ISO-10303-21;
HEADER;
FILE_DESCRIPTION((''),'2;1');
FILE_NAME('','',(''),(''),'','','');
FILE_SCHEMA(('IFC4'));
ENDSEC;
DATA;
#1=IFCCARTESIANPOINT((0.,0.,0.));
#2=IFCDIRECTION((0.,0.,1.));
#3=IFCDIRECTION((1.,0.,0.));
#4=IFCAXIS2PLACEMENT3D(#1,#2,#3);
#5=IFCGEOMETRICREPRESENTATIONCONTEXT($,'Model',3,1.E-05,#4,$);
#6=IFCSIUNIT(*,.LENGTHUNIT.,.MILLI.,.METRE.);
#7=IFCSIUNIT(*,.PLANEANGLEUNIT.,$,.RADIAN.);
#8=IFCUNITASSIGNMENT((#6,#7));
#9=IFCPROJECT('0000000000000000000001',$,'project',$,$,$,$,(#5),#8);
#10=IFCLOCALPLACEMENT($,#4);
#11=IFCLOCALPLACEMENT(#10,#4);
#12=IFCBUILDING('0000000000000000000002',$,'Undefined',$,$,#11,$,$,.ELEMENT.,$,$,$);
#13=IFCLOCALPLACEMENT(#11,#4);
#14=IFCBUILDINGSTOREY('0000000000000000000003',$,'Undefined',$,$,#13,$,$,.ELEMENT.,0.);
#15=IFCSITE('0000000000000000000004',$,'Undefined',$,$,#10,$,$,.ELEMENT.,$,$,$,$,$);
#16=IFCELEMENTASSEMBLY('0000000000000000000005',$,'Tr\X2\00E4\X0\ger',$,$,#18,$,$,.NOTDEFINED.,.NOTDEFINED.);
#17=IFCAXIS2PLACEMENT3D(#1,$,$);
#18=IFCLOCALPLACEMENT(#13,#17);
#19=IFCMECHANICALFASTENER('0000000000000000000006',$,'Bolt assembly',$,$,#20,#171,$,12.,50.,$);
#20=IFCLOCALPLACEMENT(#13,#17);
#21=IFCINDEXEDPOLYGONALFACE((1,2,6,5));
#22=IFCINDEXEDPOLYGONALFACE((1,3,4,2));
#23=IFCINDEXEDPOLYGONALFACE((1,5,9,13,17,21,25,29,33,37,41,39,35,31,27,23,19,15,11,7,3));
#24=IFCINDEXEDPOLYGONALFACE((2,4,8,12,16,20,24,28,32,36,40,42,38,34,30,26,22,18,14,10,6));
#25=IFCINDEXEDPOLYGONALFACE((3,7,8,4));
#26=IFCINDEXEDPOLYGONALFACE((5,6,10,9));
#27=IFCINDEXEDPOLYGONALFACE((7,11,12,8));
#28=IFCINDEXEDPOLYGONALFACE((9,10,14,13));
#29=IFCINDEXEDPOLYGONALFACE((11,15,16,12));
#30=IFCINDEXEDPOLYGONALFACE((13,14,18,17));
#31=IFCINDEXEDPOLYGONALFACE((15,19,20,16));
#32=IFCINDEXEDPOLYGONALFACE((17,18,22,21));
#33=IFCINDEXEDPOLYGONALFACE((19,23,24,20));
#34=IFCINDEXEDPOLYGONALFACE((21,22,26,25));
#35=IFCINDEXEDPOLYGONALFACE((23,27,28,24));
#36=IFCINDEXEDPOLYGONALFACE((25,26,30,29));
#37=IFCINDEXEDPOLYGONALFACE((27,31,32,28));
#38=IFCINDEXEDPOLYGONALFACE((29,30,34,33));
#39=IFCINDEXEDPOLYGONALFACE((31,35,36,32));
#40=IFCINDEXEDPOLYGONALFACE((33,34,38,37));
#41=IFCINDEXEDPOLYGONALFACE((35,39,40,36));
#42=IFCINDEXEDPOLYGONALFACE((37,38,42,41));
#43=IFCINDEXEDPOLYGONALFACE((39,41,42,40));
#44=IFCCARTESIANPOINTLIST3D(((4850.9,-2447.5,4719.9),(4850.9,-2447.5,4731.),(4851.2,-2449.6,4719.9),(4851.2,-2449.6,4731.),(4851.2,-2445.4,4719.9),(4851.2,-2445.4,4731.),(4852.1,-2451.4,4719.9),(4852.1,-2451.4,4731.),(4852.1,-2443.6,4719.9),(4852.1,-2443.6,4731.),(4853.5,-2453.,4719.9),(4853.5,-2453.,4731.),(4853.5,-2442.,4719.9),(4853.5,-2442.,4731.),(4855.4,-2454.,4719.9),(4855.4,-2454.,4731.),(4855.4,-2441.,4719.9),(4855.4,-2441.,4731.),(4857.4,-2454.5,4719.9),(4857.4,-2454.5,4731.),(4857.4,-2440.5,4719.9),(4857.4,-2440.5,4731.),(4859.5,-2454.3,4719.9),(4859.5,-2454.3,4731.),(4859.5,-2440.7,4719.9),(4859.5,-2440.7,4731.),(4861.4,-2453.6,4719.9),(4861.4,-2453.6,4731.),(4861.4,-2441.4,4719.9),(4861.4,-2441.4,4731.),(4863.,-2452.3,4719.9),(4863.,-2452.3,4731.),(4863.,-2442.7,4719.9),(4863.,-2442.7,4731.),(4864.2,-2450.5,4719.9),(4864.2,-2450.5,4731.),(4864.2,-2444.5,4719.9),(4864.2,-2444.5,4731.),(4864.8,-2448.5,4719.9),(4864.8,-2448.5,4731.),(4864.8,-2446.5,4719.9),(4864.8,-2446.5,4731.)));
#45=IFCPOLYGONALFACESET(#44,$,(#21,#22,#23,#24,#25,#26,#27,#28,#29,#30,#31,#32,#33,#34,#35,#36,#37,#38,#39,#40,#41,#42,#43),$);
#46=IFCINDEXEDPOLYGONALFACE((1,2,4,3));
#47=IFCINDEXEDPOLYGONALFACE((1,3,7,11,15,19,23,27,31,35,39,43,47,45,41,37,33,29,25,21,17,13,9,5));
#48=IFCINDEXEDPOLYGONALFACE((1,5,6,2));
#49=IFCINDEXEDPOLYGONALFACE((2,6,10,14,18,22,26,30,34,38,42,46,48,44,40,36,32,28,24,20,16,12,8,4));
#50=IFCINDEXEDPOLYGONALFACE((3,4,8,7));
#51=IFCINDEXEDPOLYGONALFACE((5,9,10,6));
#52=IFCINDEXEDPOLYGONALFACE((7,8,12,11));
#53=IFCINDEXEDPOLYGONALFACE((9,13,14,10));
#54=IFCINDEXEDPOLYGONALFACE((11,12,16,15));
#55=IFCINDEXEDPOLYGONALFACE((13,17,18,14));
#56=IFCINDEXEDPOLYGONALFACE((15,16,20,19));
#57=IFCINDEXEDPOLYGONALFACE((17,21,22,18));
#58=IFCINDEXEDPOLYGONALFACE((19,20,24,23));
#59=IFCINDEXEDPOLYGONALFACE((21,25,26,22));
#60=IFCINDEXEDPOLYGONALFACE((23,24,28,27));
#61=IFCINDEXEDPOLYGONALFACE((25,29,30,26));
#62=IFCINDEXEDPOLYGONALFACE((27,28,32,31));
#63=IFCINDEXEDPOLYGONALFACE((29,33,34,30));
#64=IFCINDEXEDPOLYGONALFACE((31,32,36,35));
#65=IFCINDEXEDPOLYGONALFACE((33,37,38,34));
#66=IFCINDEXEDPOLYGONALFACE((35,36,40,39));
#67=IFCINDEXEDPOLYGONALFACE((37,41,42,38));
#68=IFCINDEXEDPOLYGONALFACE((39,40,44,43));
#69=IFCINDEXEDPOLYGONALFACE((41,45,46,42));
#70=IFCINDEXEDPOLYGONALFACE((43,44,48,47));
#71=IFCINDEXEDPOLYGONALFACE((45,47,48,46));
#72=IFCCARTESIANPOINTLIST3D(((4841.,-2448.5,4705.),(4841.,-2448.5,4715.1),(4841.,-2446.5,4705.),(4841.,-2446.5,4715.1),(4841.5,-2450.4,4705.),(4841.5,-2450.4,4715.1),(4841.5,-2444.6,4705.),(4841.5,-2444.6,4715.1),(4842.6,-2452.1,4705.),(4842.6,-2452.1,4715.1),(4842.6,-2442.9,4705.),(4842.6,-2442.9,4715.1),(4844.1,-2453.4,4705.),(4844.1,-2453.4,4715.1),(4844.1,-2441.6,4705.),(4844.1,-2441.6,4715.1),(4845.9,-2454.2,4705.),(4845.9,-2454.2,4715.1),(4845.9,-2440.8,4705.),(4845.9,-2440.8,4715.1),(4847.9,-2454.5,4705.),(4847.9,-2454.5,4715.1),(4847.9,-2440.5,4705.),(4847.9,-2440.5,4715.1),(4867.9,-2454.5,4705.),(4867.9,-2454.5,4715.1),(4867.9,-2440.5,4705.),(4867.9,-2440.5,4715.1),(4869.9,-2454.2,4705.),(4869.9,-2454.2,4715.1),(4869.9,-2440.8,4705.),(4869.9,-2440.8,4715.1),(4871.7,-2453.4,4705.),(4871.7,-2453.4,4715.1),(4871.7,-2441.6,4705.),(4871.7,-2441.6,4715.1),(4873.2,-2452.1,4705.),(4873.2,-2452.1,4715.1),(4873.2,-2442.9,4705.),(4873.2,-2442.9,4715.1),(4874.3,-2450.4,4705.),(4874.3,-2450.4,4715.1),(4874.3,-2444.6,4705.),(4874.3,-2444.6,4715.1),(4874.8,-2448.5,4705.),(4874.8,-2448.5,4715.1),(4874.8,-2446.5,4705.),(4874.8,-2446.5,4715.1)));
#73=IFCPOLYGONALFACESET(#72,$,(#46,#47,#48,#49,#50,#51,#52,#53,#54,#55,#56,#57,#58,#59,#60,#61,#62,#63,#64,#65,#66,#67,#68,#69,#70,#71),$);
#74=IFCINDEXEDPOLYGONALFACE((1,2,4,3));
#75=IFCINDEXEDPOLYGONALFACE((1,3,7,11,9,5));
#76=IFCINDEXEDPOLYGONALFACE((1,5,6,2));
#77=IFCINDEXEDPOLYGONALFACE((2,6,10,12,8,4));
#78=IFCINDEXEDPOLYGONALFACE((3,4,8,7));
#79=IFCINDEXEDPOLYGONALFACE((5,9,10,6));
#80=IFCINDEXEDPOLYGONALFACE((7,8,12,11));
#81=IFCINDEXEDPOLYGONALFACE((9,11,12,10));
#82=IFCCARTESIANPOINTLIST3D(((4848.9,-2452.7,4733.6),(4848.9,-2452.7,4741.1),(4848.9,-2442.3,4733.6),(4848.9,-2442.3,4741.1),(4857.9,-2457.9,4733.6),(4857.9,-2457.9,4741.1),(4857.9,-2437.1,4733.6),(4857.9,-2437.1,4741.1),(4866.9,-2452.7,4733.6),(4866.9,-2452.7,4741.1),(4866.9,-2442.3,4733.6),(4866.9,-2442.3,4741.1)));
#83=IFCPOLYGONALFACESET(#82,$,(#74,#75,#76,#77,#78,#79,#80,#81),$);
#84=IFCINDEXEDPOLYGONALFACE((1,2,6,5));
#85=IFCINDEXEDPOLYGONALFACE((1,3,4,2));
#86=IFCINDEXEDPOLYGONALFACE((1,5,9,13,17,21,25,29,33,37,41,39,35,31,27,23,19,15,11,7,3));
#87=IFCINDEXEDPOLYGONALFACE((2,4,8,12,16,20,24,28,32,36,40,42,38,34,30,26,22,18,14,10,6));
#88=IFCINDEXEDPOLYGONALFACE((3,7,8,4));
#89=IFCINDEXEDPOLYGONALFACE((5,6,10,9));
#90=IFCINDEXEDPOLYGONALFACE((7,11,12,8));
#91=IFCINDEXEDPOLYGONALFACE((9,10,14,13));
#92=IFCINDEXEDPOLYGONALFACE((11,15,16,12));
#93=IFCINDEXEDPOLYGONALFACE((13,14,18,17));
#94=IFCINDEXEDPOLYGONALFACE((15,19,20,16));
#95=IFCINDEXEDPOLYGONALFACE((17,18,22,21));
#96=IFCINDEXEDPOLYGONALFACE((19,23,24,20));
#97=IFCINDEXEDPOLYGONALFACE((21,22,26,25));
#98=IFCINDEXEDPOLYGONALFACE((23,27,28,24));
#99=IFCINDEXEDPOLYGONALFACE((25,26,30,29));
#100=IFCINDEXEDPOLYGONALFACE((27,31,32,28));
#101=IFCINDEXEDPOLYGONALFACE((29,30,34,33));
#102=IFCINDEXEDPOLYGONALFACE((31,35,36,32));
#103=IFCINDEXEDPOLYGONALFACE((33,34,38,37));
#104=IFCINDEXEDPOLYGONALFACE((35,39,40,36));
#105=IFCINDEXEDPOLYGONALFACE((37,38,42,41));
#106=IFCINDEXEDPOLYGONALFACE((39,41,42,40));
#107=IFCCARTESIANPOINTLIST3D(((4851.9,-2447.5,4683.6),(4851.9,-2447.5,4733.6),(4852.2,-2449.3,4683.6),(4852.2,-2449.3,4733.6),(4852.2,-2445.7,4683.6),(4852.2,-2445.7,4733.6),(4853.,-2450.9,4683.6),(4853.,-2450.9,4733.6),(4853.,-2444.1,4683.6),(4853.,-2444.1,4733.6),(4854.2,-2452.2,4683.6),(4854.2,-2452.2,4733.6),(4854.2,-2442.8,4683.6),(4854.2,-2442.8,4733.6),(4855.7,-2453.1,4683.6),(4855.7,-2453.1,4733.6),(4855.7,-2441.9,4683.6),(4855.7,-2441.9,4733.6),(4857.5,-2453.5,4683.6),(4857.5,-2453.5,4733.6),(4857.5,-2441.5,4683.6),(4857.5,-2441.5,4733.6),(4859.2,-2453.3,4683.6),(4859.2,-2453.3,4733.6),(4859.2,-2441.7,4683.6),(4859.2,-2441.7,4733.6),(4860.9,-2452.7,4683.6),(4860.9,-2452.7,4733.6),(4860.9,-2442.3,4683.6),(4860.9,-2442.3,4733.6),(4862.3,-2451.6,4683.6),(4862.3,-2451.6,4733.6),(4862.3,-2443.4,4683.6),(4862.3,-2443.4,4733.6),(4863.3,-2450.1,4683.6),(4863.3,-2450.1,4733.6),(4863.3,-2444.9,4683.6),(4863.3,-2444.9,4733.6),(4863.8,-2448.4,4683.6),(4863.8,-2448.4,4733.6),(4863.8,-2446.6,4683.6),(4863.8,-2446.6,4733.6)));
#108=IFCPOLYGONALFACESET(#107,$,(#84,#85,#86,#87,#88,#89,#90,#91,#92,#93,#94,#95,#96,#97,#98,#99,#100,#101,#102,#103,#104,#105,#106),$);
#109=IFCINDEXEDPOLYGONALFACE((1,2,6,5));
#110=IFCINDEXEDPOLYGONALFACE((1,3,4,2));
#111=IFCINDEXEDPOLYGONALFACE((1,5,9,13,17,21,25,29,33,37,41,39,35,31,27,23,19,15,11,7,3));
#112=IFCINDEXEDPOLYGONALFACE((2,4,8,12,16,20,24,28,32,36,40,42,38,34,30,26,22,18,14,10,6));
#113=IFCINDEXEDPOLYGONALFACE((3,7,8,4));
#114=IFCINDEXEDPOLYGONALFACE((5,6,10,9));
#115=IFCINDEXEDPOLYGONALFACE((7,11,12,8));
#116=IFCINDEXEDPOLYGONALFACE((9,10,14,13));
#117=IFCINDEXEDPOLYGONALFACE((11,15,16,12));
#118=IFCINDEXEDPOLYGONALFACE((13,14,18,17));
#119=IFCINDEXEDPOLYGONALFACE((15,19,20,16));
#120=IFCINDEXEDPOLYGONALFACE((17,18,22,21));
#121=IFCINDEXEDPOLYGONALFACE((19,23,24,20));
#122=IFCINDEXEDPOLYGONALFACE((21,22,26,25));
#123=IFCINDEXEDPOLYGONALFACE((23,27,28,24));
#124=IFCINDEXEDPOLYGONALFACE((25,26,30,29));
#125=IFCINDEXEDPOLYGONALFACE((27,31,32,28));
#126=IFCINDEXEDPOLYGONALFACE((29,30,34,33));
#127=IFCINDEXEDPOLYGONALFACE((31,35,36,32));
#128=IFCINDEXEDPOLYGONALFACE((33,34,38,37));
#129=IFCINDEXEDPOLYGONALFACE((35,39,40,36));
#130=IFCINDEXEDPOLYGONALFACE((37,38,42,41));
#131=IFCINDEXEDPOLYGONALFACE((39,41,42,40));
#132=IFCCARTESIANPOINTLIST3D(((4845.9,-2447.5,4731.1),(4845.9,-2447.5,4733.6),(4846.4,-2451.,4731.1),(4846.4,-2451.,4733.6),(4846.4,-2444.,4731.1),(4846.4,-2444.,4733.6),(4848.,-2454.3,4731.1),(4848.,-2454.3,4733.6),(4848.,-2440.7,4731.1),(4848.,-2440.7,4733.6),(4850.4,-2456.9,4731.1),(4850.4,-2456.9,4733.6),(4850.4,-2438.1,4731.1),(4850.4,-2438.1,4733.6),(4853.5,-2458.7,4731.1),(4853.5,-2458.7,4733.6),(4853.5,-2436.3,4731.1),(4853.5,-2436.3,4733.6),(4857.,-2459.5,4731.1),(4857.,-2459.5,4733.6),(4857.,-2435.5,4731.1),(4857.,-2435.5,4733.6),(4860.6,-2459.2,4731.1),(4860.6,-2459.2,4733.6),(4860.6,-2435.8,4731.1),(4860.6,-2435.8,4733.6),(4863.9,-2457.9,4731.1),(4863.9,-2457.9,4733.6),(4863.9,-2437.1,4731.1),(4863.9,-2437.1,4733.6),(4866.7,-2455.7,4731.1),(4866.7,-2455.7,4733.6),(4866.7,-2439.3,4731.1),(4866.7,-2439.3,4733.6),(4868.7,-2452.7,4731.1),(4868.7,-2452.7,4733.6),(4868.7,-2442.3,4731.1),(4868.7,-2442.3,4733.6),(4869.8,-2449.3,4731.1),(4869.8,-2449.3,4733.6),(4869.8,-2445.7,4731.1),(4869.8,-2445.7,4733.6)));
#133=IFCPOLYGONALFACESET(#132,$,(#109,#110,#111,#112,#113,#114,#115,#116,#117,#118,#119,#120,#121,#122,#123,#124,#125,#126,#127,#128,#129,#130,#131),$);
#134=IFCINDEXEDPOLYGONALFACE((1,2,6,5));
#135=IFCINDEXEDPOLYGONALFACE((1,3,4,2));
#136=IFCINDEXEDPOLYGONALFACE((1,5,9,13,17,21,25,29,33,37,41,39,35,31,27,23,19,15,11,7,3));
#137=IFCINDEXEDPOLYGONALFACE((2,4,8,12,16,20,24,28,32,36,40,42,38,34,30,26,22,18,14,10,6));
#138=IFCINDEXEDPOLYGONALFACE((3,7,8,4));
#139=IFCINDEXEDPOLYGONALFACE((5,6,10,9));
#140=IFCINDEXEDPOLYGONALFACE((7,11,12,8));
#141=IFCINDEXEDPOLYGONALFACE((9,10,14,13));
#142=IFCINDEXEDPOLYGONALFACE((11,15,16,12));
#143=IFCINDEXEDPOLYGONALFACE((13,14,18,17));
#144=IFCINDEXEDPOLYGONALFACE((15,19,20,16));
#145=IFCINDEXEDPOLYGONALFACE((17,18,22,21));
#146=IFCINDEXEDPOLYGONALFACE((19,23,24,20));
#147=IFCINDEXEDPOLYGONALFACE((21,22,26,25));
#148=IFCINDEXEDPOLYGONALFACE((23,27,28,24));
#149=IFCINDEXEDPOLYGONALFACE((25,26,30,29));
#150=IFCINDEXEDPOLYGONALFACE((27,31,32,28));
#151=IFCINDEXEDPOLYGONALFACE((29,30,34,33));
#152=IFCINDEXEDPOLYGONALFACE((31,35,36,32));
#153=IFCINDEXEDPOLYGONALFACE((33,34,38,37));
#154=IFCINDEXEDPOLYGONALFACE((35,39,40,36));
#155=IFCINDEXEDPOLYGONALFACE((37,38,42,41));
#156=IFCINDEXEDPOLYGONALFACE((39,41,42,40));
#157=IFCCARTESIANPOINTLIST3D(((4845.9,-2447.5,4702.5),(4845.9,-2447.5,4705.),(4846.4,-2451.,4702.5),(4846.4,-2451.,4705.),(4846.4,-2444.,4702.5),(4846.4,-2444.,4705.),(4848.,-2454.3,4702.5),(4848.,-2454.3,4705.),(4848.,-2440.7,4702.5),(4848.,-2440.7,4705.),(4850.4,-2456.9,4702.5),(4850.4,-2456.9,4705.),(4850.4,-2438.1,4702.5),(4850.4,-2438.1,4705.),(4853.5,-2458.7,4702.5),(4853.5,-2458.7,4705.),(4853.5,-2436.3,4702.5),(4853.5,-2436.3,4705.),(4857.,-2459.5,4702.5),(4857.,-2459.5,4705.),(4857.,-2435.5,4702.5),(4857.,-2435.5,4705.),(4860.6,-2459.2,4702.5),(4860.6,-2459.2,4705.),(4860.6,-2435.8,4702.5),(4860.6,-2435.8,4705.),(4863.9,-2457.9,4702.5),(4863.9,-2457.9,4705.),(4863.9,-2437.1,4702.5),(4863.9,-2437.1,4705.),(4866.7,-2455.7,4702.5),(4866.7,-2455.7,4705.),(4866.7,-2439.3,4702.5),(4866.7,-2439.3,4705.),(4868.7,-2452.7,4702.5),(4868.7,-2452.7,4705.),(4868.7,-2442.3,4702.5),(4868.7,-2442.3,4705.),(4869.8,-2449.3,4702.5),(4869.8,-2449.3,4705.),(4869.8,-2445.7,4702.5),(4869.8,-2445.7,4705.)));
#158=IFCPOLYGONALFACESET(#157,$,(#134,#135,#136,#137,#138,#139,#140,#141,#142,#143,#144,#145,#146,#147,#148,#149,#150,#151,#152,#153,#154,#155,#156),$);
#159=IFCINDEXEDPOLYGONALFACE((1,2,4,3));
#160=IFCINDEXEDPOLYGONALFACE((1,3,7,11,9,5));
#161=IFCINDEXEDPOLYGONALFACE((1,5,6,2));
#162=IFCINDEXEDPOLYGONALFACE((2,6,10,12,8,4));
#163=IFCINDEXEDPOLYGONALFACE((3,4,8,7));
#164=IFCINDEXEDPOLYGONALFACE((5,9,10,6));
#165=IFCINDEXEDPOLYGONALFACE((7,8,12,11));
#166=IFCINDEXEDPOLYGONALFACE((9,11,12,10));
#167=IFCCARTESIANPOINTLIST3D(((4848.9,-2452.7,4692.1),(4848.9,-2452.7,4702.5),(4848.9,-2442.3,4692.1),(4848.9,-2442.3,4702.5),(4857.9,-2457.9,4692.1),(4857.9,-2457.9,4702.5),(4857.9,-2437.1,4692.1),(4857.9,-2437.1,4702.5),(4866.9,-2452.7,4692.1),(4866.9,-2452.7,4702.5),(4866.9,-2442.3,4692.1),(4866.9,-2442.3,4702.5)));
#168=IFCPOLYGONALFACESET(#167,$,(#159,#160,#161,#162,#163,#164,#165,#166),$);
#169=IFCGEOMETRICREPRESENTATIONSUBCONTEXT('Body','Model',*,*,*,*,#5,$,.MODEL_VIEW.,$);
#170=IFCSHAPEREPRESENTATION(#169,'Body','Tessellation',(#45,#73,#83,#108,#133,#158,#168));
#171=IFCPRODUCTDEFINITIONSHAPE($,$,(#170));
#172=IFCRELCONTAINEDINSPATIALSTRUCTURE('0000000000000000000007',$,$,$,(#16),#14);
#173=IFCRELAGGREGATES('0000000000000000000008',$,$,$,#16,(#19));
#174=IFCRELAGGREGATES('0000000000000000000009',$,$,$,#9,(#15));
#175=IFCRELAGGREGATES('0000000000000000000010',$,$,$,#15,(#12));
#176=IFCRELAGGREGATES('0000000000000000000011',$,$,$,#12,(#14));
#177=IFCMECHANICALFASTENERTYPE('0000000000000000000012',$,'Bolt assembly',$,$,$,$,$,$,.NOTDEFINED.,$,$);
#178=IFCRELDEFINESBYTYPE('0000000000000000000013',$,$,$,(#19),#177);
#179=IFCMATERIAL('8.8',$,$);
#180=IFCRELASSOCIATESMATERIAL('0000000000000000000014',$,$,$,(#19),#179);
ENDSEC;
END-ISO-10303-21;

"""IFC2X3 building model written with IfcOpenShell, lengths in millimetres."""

from ifc_helpers import new_model, si_unit, frame, frame_2d, origin_with_axes, origin_2d_with_axis, place, context, subcontext, project, spatial, polyline, circle_curve, parameter, trimmed, segment, composite_curve, circle, outline, extrude, source, transform, mapped, material, type_object, element, aggregate, save


model = new_model("IFC2X3")

# Units and contexts
model_context = context("Model", 3, precision=1e-05, world=origin_with_axes())
body_context = subcontext(model_context, "Body", "Model", "MODEL_VIEW")
ifc_project = project(units=[si_unit("LENGTHUNIT", "METRE", prefix="MILLI"), si_unit("PLANEANGLEUNIT", "RADIAN")], contexts=[model_context])

# Site, building, storey
site_placement = place(None, origin_with_axes())
site = spatial("IfcSite", under=ifc_project, at=site_placement, Name="Undefined", CompositionType="ELEMENT")
building_placement = place(site_placement, origin_with_axes())
building = spatial("IfcBuilding", under=site, at=building_placement, Name="Undefined", CompositionType="ELEMENT")
storey_placement = place(building_placement, origin_with_axes())
storey = spatial("IfcBuildingStorey", under=building, at=storey_placement, Name="Undefined", CompositionType="ELEMENT", Elevation=0.0)

# Element assembly, mechanical fastener
assembly_placement = place(storey_placement, origin_with_axes())
assembly = element("IfcElementAssembly", 1, at=assembly_placement, inside=storey, Name="Träger", AssemblyPlace="NOTDEFINED", PredefinedType="NOTDEFINED")
ifc_material_1 = material(Name="8.8")
mechanical_fastener_type = type_object("IfcMechanicalFastenerType", Name="Bolt assembly")
shared_shape_1 = source(origin_with_axes(), body_context, "Body", "SweptSolid", [
    extrude(circle(Radius=7.0, at=origin_2d_with_axis()), frame((0.0, -26.0, 0.0), z_axis=(0.0, 1.0, 0.0), x_axis=(1.0, 0.0, 0.0)), (0.0, 0.0, 1.0), 11.1),
    extrude(outline(composite_curve([segment(polyline([(-10.0, 7.0), (10.0, 7.0)]), True, "CONTINUOUS"), segment(trimmed(circle_curve(frame_2d((10.0, 0.0), x_axis=(0.0, 1.0)), 7.0), [parameter(0.0)], [parameter(3.141593)], False, "PARAMETER"), True, "CONTINUOUS"), segment(polyline([(10.0, -7.0), (-10.0, -7.0)]), True, "CONTINUOUS"), segment(trimmed(circle_curve(frame_2d((-10.0, 0.0), x_axis=(0.0, -1.0)), 7.0), [parameter(0.0)], [parameter(3.141593)], False, "PARAMETER"), True, "DISCONTINUOUS")], self_intersect=False)), frame((0.0, -10.1, 0.0), z_axis=(0.0, 1.0, 0.0), x_axis=(1.0, 0.0, 0.0)), (0.0, 0.0, 1.0), 10.1),
    extrude(outline(polyline([(9.0, -5.2), (9.0, 5.2), (0.0, 10.4), (-9.0, 5.2), (-9.0, -5.2), (0.0, -10.4), (9.0, -5.2)])), frame((0.0, -36.1, 0.0), z_axis=(0.0, 1.0, 0.0), x_axis=(1.0, 0.0, 0.0)), (0.0, 0.0, 1.0), 7.5),
    extrude(circle(Radius=6.0, at=origin_2d_with_axis()), frame((0.0, -28.6, 0.0), z_axis=(0.0, 1.0, 0.0), x_axis=(1.0, 0.0, 0.0)), (0.0, 0.0, 1.0), 50.0),
    extrude(circle(Radius=12.0, at=origin_2d_with_axis()), frame((0.0, -28.6, 0.0), z_axis=(0.0, 1.0, 0.0), x_axis=(1.0, 0.0, 0.0)), (0.0, 0.0, 1.0), 2.5),
    extrude(circle(Radius=12.0, at=origin_2d_with_axis()), frame((0.0, 0.0, 0.0), z_axis=(0.0, 1.0, 0.0), x_axis=(1.0, 0.0, 0.0)), (0.0, 0.0, 1.0), 2.5),
    extrude(outline(polyline([(9.0, -5.2), (9.0, 5.2), (0.0, 10.4), (-9.0, 5.2), (-9.0, -5.2), (0.0, -10.4), (9.0, -5.2)])), frame((0.0, 2.5, 0.0), z_axis=(0.0, 1.0, 0.0), x_axis=(1.0, 0.0, 0.0)), (0.0, 0.0, 1.0), 10.4),
])
mechanical_fastener_1_placement = place(assembly_placement, frame((4857.9, -2447.5, 4705.0), z_axis=(0.0, -1.0, 0.0), x_axis=(-1.0, 0.0, 0.0)))
mechanical_fastener_1 = element("IfcMechanicalFastener", 2, at=mechanical_fastener_1_placement, type_object=mechanical_fastener_type, material=ifc_material_1, Name="Bolt assembly", NominalDiameter=12.0, NominalLength=50.0, context=body_context, shape_type="MappedRepresentation", body=[
    mapped(shared_shape_1, transform((0.0, 0.0, 0.0))),
])
aggregate(assembly, [mechanical_fastener_1])

save(model, "model.ifc")
